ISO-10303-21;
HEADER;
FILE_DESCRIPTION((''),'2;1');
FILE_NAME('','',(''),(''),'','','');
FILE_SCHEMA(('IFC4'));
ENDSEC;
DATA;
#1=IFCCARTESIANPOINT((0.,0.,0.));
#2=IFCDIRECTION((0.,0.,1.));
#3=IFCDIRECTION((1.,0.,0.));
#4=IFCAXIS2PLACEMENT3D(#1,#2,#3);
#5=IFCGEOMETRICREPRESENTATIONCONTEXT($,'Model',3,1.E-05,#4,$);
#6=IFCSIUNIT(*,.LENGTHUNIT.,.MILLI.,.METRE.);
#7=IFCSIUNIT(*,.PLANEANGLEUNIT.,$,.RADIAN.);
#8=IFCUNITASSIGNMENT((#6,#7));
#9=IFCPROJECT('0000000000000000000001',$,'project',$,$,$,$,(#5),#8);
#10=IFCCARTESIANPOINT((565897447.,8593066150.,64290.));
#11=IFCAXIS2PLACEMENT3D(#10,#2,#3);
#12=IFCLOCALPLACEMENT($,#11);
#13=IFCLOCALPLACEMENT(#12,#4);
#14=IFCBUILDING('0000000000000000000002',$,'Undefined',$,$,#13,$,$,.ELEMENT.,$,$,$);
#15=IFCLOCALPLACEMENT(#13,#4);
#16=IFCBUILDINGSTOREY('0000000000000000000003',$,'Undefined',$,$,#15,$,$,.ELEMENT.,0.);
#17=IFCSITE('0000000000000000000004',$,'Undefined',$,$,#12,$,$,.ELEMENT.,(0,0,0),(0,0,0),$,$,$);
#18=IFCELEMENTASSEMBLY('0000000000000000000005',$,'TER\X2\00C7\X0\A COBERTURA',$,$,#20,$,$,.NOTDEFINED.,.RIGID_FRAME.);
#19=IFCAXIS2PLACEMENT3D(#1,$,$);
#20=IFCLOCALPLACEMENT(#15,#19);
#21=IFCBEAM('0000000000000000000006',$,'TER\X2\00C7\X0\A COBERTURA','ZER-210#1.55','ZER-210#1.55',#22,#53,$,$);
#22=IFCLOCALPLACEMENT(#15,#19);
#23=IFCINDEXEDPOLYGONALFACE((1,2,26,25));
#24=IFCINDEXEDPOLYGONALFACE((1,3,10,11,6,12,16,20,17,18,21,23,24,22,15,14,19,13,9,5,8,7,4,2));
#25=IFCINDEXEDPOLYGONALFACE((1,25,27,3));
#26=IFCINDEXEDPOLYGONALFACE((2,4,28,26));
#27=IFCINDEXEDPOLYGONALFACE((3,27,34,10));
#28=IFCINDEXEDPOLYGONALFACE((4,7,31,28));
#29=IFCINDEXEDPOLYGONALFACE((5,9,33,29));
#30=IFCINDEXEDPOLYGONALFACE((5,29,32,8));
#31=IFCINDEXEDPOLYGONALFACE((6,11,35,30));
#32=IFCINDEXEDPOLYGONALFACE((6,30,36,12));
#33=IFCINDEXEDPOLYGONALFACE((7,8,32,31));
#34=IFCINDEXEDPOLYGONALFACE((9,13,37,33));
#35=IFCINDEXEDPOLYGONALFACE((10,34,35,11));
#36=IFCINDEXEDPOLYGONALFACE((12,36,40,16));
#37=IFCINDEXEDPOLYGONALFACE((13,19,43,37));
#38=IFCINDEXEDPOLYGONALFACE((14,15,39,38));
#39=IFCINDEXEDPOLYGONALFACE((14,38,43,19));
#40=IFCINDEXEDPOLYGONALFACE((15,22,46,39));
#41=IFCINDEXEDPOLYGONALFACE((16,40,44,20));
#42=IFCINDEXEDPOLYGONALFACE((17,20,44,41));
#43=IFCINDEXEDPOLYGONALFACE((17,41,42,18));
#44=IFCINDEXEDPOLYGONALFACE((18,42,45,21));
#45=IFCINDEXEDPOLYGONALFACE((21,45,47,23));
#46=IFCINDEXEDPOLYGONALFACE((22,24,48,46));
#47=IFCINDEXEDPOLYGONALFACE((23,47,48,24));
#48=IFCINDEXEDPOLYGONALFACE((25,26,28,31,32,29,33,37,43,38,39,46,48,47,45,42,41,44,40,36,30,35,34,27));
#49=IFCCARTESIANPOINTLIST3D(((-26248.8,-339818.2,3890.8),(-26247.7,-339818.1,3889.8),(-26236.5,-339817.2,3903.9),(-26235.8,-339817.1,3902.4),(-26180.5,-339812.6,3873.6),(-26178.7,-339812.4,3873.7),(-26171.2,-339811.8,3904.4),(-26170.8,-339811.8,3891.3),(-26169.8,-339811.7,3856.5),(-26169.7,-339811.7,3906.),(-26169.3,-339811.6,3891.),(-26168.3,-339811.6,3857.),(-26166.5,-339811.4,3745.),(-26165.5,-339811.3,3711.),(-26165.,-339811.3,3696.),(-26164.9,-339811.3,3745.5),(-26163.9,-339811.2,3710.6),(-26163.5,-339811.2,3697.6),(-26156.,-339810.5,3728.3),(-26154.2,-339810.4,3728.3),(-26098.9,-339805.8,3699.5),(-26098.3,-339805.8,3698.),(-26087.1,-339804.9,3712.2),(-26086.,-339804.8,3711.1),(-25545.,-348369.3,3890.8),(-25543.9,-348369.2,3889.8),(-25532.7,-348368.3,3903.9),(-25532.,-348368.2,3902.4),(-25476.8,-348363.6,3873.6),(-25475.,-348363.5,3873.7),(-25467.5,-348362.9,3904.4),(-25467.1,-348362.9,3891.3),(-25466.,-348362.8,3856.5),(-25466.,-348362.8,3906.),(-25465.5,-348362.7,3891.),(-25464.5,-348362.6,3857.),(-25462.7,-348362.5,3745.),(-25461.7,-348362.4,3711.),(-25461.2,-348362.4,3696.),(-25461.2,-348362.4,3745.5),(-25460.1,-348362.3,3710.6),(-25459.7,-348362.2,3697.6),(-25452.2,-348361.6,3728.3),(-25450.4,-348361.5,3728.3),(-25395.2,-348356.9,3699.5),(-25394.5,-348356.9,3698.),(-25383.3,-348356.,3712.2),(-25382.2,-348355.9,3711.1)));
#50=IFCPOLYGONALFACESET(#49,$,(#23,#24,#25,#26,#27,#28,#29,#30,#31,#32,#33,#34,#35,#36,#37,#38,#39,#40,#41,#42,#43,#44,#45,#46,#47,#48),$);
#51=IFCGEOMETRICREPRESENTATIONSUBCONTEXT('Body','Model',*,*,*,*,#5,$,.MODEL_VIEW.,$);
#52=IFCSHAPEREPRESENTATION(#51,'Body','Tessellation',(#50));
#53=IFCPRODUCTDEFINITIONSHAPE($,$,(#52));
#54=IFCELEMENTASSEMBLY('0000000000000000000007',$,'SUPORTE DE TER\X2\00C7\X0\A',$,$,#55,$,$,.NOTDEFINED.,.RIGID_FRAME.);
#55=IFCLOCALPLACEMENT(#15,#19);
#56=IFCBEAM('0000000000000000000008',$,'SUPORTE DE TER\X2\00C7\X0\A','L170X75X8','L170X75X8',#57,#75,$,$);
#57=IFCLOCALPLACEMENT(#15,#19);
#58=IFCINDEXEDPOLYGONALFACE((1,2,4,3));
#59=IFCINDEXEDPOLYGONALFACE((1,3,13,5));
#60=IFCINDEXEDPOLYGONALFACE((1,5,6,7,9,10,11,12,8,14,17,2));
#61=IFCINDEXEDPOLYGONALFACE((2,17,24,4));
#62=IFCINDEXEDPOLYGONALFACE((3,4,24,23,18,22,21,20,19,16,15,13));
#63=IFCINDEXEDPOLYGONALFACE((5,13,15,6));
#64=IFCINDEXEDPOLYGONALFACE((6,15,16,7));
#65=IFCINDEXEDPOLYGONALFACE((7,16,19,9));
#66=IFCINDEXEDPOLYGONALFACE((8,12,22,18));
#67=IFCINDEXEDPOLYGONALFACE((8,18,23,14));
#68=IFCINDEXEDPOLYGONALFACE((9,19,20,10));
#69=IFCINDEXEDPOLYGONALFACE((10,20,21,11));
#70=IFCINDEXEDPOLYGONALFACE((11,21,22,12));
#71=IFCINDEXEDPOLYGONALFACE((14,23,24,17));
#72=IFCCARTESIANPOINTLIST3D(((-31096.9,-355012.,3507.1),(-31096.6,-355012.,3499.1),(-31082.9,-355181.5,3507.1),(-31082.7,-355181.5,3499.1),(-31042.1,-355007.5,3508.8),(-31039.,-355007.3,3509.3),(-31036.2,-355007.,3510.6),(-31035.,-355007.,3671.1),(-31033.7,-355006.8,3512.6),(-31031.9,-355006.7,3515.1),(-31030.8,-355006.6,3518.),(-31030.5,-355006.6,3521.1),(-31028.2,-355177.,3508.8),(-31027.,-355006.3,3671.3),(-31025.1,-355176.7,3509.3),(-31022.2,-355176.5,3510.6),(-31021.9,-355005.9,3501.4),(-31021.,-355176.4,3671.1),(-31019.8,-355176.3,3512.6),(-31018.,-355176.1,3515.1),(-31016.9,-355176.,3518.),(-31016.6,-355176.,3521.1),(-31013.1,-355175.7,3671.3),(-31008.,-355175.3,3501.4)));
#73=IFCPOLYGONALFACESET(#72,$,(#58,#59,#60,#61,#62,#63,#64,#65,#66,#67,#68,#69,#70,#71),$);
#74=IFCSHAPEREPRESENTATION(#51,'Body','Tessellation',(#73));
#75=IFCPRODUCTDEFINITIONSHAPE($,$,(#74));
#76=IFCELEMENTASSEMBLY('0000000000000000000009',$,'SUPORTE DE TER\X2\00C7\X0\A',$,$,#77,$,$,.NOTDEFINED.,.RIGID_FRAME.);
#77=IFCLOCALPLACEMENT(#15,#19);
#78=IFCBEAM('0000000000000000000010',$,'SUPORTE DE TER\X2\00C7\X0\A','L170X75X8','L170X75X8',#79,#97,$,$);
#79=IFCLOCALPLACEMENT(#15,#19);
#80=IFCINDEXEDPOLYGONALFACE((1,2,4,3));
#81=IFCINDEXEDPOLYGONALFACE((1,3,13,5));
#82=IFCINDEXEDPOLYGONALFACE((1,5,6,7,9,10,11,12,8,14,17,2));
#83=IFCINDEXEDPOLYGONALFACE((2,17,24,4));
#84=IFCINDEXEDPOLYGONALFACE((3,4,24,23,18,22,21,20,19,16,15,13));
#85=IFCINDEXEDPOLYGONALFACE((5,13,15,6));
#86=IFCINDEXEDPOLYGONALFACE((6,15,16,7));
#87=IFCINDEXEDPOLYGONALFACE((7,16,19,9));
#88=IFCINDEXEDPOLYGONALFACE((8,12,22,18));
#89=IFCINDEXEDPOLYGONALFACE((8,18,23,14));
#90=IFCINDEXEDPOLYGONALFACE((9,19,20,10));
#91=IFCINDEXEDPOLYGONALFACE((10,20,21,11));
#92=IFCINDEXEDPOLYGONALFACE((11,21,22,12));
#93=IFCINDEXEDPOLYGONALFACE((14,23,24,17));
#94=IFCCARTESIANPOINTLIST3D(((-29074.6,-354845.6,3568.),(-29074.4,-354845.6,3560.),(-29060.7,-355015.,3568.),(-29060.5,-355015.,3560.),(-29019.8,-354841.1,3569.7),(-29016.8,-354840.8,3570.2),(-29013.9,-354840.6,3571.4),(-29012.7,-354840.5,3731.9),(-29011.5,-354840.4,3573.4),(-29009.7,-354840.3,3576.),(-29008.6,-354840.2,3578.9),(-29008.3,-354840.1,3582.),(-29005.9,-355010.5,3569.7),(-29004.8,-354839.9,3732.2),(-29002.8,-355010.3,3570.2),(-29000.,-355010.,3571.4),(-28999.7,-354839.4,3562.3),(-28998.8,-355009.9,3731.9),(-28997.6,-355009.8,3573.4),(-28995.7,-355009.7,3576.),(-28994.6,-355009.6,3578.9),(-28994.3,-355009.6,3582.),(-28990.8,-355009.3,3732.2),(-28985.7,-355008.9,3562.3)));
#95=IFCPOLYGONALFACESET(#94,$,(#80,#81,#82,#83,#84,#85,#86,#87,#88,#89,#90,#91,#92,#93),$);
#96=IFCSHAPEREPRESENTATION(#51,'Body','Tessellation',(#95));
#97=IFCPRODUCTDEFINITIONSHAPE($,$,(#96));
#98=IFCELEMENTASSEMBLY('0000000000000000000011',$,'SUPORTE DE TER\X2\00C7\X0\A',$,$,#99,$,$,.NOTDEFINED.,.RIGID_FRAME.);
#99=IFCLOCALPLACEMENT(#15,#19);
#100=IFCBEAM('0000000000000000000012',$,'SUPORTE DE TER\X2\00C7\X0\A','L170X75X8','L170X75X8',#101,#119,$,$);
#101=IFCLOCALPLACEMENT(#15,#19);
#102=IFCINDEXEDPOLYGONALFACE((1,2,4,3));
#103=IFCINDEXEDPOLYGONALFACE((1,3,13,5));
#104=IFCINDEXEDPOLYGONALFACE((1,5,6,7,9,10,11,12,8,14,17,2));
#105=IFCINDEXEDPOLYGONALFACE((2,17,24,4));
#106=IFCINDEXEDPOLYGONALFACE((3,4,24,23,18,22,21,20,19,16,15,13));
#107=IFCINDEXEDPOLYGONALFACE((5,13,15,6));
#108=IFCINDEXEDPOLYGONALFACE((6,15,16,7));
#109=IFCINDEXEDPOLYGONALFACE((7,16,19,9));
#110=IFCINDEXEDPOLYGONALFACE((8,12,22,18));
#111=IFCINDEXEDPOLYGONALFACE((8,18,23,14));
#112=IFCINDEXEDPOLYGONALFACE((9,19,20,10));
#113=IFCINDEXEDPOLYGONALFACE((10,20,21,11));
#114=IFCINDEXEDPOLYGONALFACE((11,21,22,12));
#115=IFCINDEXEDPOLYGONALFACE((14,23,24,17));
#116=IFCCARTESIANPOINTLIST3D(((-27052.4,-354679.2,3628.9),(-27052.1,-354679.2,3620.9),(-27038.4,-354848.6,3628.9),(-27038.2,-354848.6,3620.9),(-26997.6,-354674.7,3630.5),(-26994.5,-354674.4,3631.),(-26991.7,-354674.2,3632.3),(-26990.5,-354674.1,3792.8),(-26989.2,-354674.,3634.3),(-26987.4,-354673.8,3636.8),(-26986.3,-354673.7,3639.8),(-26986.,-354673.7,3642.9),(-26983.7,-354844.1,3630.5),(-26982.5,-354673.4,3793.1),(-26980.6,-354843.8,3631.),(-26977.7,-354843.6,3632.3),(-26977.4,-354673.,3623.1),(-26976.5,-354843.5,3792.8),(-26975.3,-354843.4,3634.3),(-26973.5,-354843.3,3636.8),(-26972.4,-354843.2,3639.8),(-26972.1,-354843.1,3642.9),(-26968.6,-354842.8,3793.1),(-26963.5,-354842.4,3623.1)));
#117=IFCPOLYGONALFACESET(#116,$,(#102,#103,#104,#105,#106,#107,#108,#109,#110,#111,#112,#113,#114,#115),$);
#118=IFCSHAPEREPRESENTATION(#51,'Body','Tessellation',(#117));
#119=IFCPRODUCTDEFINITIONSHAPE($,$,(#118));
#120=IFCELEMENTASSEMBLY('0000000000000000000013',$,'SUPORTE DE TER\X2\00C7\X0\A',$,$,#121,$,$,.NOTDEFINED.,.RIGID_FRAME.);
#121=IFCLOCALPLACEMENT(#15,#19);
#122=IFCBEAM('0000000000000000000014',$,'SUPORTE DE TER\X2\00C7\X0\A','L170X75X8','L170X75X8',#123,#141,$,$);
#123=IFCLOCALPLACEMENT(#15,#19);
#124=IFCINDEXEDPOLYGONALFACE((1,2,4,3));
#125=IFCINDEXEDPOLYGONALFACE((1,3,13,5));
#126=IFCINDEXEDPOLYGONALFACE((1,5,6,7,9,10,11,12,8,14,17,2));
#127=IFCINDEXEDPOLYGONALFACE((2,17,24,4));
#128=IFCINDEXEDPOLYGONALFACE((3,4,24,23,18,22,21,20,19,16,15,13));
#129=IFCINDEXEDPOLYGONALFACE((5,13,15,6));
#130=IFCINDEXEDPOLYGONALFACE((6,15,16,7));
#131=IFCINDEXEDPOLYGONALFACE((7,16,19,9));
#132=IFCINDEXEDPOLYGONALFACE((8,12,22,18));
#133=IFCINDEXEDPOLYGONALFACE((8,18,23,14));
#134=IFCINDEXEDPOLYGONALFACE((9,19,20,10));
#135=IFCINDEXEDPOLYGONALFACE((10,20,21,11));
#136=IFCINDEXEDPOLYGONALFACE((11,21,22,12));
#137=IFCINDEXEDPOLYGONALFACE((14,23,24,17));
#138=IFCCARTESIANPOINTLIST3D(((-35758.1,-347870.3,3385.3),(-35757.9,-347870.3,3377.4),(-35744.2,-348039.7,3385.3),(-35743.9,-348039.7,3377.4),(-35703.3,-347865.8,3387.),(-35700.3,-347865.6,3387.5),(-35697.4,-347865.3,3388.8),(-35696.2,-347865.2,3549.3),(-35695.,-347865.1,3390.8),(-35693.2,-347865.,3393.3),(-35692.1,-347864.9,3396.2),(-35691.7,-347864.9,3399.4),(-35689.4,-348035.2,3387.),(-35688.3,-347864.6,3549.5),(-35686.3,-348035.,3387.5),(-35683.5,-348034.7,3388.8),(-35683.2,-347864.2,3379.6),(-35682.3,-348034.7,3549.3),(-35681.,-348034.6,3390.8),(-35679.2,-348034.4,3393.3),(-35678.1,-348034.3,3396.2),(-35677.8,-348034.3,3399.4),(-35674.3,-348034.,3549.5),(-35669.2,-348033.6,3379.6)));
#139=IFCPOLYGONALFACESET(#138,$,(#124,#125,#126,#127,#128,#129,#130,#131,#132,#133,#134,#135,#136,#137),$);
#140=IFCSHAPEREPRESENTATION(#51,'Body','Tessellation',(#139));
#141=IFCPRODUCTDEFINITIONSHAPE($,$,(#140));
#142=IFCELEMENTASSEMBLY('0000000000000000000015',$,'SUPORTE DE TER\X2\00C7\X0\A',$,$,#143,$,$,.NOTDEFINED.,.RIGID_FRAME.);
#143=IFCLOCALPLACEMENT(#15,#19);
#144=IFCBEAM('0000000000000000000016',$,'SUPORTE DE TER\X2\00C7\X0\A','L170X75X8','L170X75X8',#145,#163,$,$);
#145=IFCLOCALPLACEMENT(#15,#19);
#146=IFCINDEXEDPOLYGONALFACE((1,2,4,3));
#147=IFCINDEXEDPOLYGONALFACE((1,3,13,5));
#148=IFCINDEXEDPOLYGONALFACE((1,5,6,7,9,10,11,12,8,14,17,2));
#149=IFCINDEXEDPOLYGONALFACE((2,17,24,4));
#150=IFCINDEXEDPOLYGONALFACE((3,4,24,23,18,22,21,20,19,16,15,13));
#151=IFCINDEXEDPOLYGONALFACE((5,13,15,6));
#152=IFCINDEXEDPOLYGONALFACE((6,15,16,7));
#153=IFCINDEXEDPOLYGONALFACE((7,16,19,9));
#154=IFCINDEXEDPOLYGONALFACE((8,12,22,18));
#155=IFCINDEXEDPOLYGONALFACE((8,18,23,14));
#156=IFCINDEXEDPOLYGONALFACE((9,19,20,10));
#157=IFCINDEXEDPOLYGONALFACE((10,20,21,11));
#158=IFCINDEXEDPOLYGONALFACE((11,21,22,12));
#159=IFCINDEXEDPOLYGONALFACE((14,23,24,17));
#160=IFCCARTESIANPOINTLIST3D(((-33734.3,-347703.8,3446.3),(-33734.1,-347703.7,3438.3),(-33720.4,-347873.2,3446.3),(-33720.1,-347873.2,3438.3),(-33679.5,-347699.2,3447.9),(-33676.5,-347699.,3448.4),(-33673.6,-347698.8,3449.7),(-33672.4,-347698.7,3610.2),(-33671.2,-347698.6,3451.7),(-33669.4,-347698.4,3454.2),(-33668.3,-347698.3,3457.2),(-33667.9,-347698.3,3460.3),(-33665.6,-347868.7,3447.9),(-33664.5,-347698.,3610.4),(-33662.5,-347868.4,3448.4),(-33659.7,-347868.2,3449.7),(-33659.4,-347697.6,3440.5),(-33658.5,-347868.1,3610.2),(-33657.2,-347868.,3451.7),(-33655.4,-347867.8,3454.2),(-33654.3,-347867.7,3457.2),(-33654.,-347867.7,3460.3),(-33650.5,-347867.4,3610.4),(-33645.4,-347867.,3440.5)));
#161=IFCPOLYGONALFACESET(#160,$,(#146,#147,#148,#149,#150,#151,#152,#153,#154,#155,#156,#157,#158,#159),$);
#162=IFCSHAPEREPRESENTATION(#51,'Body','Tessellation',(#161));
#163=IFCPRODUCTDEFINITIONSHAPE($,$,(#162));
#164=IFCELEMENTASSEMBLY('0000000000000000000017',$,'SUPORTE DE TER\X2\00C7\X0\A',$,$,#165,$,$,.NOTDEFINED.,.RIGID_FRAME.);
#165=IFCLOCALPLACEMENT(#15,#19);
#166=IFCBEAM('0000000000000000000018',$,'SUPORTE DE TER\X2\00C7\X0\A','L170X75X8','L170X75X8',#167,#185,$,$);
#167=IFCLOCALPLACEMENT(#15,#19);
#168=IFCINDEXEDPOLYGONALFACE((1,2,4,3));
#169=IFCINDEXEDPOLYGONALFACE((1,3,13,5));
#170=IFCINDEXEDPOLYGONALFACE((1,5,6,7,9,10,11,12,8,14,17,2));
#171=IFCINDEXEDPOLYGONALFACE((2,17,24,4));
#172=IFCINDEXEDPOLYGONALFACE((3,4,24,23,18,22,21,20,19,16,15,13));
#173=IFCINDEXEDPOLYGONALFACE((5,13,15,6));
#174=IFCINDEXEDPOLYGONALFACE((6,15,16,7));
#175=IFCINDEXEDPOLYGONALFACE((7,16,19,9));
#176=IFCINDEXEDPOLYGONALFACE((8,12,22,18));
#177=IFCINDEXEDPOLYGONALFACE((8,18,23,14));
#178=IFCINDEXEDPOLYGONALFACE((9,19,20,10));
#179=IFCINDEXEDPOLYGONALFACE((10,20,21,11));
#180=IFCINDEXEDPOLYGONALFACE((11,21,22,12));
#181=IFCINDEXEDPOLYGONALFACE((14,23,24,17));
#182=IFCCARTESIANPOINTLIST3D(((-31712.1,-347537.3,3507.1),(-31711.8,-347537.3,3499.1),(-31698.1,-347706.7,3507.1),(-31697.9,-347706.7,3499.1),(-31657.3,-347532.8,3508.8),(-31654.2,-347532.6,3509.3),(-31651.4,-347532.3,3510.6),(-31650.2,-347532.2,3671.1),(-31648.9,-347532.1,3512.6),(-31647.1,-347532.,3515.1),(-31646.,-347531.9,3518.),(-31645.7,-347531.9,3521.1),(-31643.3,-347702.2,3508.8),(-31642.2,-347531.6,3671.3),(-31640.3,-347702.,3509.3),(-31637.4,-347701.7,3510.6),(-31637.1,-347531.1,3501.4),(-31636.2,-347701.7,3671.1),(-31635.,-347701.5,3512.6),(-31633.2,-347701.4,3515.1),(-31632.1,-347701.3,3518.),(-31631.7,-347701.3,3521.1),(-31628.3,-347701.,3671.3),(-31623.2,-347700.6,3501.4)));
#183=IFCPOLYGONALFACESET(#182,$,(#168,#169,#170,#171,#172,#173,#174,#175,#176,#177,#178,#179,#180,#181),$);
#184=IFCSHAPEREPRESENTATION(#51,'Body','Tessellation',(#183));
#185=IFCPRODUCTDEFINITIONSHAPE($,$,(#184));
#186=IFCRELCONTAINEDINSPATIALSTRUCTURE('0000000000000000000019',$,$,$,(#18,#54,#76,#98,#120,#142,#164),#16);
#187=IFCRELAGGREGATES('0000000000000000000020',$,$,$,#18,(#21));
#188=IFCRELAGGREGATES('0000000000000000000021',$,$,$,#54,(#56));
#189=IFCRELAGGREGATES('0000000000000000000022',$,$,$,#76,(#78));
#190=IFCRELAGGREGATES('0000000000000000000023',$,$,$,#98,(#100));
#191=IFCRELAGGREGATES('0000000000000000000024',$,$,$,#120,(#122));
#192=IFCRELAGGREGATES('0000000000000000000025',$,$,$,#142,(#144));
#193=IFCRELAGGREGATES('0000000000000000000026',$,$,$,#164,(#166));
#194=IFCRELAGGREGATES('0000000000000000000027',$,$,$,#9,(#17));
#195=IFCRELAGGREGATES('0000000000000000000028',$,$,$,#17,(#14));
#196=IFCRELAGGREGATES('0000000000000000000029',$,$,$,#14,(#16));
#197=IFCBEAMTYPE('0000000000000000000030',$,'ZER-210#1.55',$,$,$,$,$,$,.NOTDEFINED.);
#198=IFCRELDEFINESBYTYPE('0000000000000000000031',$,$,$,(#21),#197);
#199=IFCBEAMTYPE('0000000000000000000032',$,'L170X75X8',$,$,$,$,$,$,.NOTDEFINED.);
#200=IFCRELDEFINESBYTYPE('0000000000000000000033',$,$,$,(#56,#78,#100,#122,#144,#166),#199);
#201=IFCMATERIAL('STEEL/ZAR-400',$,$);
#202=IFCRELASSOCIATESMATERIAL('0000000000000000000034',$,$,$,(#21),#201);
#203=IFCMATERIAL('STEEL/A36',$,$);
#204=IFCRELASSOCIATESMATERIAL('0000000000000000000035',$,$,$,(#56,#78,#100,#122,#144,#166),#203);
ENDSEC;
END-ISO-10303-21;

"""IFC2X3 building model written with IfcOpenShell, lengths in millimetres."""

from ifc_helpers import new_model, si_unit, frame, origin_with_axes, origin_2d_with_axis, place, context, subcontext, project, spatial, polyline, l_section, outline, extrude, material, type_object, element, aggregate, save


model = new_model("IFC2X3")

# Units and contexts
model_context = context("Model", 3, precision=1e-05, world=origin_with_axes())
body_context = subcontext(model_context, "Body", "Model", "MODEL_VIEW")
ifc_project = project(units=[si_unit("LENGTHUNIT", "METRE", prefix="MILLI"), si_unit("PLANEANGLEUNIT", "RADIAN")], contexts=[model_context])

# Site, building, storey
site_placement = place(None, frame((565897447.0, 8593066150.0, 64290.0), z_axis=(0.0, 0.0, 1.0), x_axis=(1.0, 0.0, 0.0)))
site = spatial("IfcSite", under=ifc_project, at=site_placement, Name="Undefined", CompositionType="ELEMENT", RefLatitude=(0, 0, 0), RefLongitude=(0, 0, 0))
building_placement = place(site_placement, origin_with_axes())
building = spatial("IfcBuilding", under=site, at=building_placement, Name="Undefined", CompositionType="ELEMENT")
storey_placement = place(building_placement, origin_with_axes())
storey = spatial("IfcBuildingStorey", under=building, at=storey_placement, Name="Undefined", CompositionType="ELEMENT", Elevation=0.0)

# Element assemblies, beams
ifc_material_1 = material(Name="STEEL/ZAR-400")
beam_type_1 = type_object("IfcBeamType", Name="ZER-210#1.55", PredefinedType="NOTDEFINED")
assembly_1_placement = place(storey_placement, origin_with_axes())
assembly_1 = element("IfcElementAssembly", 1, at=assembly_1_placement, inside=storey, Name="TERÇA COBERTURA", AssemblyPlace="NOTDEFINED", PredefinedType="RIGID_FRAME")
beam_1_placement = place(assembly_1_placement, frame((-25463.6, -348362.6, 3801.0), z_axis=(-0.029885, -0.00246, 0.99955), x_axis=(-0.082025, 0.99663, 0.0)))
beam_1 = element("IfcBeam", 2, at=beam_1_placement, type_object=beam_type_1, material=ifc_material_1, Name="TERÇA COBERTURA", Description="ZER-210#1.55", ObjectType="ZER-210#1.55", context=body_context, shape_type="SweptSolid", body=[
    extrude(outline(polyline([(65.6, -103.4), (77.9, -91.2), (79.0, -92.3), (66.2, -105.0), (-0.8, -105.0), (-0.8, -90.0), (9.2, -73.0), (-0.8, -56.0), (-0.8, 55.6), (-11.0, 73.0), (-0.8, 90.4), (-0.8, 103.5), (-65.6, 103.4), (-77.9, 91.2), (-79.0, 92.3), (-66.2, 105.0), (0.8, 105.0), (0.8, 90.0), (-9.2, 73.0), (0.8, 56.0), (0.8, -55.6), (11.0, -73.0), (0.8, -90.4), (0.8, -103.5), (65.6, -103.4)])), frame((8580.0, 0.0, 0.0), z_axis=(-1.0, 0.0, 0.0), x_axis=(0.0, -1.0, 0.0)), (0.0, 0.0, 1.0), 8580.0),
])
aggregate(assembly_1, [beam_1])
assembly_2_placement = place(storey_placement, origin_with_axes())
assembly_2 = element("IfcElementAssembly", 3, at=assembly_2_placement, inside=storey, Name="SUPORTE DE TERÇA", AssemblyPlace="NOTDEFINED", PredefinedType="RIGID_FRAME")
ifc_material_2 = material(Name="STEEL/A36")
beam_type_2 = type_object("IfcBeamType", Name="L170X75X8", PredefinedType="NOTDEFINED")
beam_2_placement = place(assembly_2_placement, frame((-31061.8, -355009.2, 3585.2), z_axis=(-0.029885, -0.00246, 0.99955), x_axis=(0.082025, -0.99663, 0.0)))
beam_2 = element("IfcBeam", 4, at=beam_2_placement, type_object=beam_type_2, material=ifc_material_2, Name="SUPORTE DE TERÇA", Description="L170X75X8", ObjectType="L170X75X8", context=body_context, shape_type="SweptSolid", body=[
    extrude(l_section(Depth=170.0, Width=75.0, Thickness=8.0, FilletRadius=12.0, at=origin_2d_with_axis()), frame((170.0, 0.0, 0.0), z_axis=(-1.0, 0.0, 0.0), x_axis=(0.0, -1.0, 0.0)), (0.0, 0.0, 1.0), 170.0),
])
aggregate(assembly_2, [beam_2])
assembly_3_placement = place(storey_placement, origin_with_axes())
assembly_3 = element("IfcElementAssembly", 5, at=assembly_3_placement, inside=storey, Name="SUPORTE DE TERÇA", AssemblyPlace="NOTDEFINED", PredefinedType="RIGID_FRAME")
beam_3_placement = place(assembly_3_placement, frame((-29039.6, -354842.7, 3646.1), z_axis=(-0.029885, -0.00246, 0.99955), x_axis=(0.082025, -0.99663, 0.0)))
beam_3 = element("IfcBeam", 6, at=beam_3_placement, type_object=beam_type_2, material=ifc_material_2, Name="SUPORTE DE TERÇA", Description="L170X75X8", ObjectType="L170X75X8", context=body_context, shape_type="SweptSolid", body=[
    extrude(l_section(Depth=170.0, Width=75.0, Thickness=8.0, FilletRadius=12.0, at=origin_2d_with_axis()), frame((170.0, 0.0, 0.0), z_axis=(-1.0, 0.0, 0.0), x_axis=(0.0, -1.0, 0.0)), (0.0, 0.0, 1.0), 170.0),
])
aggregate(assembly_3, [beam_3])
assembly_4_placement = place(storey_placement, origin_with_axes())
assembly_4 = element("IfcElementAssembly", 7, at=assembly_4_placement, inside=storey, Name="SUPORTE DE TERÇA", AssemblyPlace="NOTDEFINED", PredefinedType="RIGID_FRAME")
beam_4_placement = place(assembly_4_placement, frame((-27017.3, -354676.3, 3707.0), z_axis=(-0.029885, -0.00246, 0.99955), x_axis=(0.082025, -0.99663, 0.0)))
beam_4 = element("IfcBeam", 8, at=beam_4_placement, type_object=beam_type_2, material=ifc_material_2, Name="SUPORTE DE TERÇA", Description="L170X75X8", ObjectType="L170X75X8", context=body_context, shape_type="SweptSolid", body=[
    extrude(l_section(Depth=170.0, Width=75.0, Thickness=8.0, FilletRadius=12.0, at=origin_2d_with_axis()), frame((170.0, 0.0, 0.0), z_axis=(-1.0, 0.0, 0.0), x_axis=(0.0, -1.0, 0.0)), (0.0, 0.0, 1.0), 170.0),
])
aggregate(assembly_4, [beam_4])
assembly_5_placement = place(storey_placement, origin_with_axes())
assembly_5 = element("IfcElementAssembly", 9, at=assembly_5_placement, inside=storey, Name="SUPORTE DE TERÇA", AssemblyPlace="NOTDEFINED", PredefinedType="RIGID_FRAME")
beam_5_placement = place(assembly_5_placement, frame((-35723.1, -347867.4, 3463.4), z_axis=(-0.029885, -0.00246, 0.99955), x_axis=(0.082025, -0.99663, 0.0)))
beam_5 = element("IfcBeam", 10, at=beam_5_placement, type_object=beam_type_2, material=ifc_material_2, Name="SUPORTE DE TERÇA", Description="L170X75X8", ObjectType="L170X75X8", context=body_context, shape_type="SweptSolid", body=[
    extrude(l_section(Depth=170.0, Width=75.0, Thickness=8.0, FilletRadius=12.0, at=origin_2d_with_axis()), frame((170.0, 0.0, 0.0), z_axis=(-1.0, 0.0, 0.0), x_axis=(0.0, -1.0, 0.0)), (0.0, 0.0, 1.0), 170.0),
])
aggregate(assembly_5, [beam_5])
assembly_6_placement = place(storey_placement, origin_with_axes())
assembly_6 = element("IfcElementAssembly", 11, at=assembly_6_placement, inside=storey, Name="SUPORTE DE TERÇA", AssemblyPlace="NOTDEFINED", PredefinedType="RIGID_FRAME")
beam_6_placement = place(assembly_6_placement, frame((-33699.3, -347700.9, 3524.4), z_axis=(-0.029885, -0.00246, 0.99955), x_axis=(0.082025, -0.99663, 0.0)))
beam_6 = element("IfcBeam", 12, at=beam_6_placement, type_object=beam_type_2, material=ifc_material_2, Name="SUPORTE DE TERÇA", Description="L170X75X8", ObjectType="L170X75X8", context=body_context, shape_type="SweptSolid", body=[
    extrude(l_section(Depth=170.0, Width=75.0, Thickness=8.0, FilletRadius=12.0, at=origin_2d_with_axis()), frame((170.0, 0.0, 0.0), z_axis=(-1.0, 0.0, 0.0), x_axis=(0.0, -1.0, 0.0)), (0.0, 0.0, 1.0), 170.0),
])
aggregate(assembly_6, [beam_6])
assembly_7_placement = place(storey_placement, origin_with_axes())
assembly_7 = element("IfcElementAssembly", 13, at=assembly_7_placement, inside=storey, Name="SUPORTE DE TERÇA", AssemblyPlace="NOTDEFINED", PredefinedType="RIGID_FRAME")
beam_7_placement = place(assembly_7_placement, frame((-31677.0, -347534.4, 3585.2), z_axis=(-0.029885, -0.00246, 0.99955), x_axis=(0.082025, -0.99663, 0.0)))
beam_7 = element("IfcBeam", 14, at=beam_7_placement, type_object=beam_type_2, material=ifc_material_2, Name="SUPORTE DE TERÇA", Description="L170X75X8", ObjectType="L170X75X8", context=body_context, shape_type="SweptSolid", body=[
    extrude(l_section(Depth=170.0, Width=75.0, Thickness=8.0, FilletRadius=12.0, at=origin_2d_with_axis()), frame((170.0, 0.0, 0.0), z_axis=(-1.0, 0.0, 0.0), x_axis=(0.0, -1.0, 0.0)), (0.0, 0.0, 1.0), 170.0),
])
aggregate(assembly_7, [beam_7])

save(model, "model.ifc")
